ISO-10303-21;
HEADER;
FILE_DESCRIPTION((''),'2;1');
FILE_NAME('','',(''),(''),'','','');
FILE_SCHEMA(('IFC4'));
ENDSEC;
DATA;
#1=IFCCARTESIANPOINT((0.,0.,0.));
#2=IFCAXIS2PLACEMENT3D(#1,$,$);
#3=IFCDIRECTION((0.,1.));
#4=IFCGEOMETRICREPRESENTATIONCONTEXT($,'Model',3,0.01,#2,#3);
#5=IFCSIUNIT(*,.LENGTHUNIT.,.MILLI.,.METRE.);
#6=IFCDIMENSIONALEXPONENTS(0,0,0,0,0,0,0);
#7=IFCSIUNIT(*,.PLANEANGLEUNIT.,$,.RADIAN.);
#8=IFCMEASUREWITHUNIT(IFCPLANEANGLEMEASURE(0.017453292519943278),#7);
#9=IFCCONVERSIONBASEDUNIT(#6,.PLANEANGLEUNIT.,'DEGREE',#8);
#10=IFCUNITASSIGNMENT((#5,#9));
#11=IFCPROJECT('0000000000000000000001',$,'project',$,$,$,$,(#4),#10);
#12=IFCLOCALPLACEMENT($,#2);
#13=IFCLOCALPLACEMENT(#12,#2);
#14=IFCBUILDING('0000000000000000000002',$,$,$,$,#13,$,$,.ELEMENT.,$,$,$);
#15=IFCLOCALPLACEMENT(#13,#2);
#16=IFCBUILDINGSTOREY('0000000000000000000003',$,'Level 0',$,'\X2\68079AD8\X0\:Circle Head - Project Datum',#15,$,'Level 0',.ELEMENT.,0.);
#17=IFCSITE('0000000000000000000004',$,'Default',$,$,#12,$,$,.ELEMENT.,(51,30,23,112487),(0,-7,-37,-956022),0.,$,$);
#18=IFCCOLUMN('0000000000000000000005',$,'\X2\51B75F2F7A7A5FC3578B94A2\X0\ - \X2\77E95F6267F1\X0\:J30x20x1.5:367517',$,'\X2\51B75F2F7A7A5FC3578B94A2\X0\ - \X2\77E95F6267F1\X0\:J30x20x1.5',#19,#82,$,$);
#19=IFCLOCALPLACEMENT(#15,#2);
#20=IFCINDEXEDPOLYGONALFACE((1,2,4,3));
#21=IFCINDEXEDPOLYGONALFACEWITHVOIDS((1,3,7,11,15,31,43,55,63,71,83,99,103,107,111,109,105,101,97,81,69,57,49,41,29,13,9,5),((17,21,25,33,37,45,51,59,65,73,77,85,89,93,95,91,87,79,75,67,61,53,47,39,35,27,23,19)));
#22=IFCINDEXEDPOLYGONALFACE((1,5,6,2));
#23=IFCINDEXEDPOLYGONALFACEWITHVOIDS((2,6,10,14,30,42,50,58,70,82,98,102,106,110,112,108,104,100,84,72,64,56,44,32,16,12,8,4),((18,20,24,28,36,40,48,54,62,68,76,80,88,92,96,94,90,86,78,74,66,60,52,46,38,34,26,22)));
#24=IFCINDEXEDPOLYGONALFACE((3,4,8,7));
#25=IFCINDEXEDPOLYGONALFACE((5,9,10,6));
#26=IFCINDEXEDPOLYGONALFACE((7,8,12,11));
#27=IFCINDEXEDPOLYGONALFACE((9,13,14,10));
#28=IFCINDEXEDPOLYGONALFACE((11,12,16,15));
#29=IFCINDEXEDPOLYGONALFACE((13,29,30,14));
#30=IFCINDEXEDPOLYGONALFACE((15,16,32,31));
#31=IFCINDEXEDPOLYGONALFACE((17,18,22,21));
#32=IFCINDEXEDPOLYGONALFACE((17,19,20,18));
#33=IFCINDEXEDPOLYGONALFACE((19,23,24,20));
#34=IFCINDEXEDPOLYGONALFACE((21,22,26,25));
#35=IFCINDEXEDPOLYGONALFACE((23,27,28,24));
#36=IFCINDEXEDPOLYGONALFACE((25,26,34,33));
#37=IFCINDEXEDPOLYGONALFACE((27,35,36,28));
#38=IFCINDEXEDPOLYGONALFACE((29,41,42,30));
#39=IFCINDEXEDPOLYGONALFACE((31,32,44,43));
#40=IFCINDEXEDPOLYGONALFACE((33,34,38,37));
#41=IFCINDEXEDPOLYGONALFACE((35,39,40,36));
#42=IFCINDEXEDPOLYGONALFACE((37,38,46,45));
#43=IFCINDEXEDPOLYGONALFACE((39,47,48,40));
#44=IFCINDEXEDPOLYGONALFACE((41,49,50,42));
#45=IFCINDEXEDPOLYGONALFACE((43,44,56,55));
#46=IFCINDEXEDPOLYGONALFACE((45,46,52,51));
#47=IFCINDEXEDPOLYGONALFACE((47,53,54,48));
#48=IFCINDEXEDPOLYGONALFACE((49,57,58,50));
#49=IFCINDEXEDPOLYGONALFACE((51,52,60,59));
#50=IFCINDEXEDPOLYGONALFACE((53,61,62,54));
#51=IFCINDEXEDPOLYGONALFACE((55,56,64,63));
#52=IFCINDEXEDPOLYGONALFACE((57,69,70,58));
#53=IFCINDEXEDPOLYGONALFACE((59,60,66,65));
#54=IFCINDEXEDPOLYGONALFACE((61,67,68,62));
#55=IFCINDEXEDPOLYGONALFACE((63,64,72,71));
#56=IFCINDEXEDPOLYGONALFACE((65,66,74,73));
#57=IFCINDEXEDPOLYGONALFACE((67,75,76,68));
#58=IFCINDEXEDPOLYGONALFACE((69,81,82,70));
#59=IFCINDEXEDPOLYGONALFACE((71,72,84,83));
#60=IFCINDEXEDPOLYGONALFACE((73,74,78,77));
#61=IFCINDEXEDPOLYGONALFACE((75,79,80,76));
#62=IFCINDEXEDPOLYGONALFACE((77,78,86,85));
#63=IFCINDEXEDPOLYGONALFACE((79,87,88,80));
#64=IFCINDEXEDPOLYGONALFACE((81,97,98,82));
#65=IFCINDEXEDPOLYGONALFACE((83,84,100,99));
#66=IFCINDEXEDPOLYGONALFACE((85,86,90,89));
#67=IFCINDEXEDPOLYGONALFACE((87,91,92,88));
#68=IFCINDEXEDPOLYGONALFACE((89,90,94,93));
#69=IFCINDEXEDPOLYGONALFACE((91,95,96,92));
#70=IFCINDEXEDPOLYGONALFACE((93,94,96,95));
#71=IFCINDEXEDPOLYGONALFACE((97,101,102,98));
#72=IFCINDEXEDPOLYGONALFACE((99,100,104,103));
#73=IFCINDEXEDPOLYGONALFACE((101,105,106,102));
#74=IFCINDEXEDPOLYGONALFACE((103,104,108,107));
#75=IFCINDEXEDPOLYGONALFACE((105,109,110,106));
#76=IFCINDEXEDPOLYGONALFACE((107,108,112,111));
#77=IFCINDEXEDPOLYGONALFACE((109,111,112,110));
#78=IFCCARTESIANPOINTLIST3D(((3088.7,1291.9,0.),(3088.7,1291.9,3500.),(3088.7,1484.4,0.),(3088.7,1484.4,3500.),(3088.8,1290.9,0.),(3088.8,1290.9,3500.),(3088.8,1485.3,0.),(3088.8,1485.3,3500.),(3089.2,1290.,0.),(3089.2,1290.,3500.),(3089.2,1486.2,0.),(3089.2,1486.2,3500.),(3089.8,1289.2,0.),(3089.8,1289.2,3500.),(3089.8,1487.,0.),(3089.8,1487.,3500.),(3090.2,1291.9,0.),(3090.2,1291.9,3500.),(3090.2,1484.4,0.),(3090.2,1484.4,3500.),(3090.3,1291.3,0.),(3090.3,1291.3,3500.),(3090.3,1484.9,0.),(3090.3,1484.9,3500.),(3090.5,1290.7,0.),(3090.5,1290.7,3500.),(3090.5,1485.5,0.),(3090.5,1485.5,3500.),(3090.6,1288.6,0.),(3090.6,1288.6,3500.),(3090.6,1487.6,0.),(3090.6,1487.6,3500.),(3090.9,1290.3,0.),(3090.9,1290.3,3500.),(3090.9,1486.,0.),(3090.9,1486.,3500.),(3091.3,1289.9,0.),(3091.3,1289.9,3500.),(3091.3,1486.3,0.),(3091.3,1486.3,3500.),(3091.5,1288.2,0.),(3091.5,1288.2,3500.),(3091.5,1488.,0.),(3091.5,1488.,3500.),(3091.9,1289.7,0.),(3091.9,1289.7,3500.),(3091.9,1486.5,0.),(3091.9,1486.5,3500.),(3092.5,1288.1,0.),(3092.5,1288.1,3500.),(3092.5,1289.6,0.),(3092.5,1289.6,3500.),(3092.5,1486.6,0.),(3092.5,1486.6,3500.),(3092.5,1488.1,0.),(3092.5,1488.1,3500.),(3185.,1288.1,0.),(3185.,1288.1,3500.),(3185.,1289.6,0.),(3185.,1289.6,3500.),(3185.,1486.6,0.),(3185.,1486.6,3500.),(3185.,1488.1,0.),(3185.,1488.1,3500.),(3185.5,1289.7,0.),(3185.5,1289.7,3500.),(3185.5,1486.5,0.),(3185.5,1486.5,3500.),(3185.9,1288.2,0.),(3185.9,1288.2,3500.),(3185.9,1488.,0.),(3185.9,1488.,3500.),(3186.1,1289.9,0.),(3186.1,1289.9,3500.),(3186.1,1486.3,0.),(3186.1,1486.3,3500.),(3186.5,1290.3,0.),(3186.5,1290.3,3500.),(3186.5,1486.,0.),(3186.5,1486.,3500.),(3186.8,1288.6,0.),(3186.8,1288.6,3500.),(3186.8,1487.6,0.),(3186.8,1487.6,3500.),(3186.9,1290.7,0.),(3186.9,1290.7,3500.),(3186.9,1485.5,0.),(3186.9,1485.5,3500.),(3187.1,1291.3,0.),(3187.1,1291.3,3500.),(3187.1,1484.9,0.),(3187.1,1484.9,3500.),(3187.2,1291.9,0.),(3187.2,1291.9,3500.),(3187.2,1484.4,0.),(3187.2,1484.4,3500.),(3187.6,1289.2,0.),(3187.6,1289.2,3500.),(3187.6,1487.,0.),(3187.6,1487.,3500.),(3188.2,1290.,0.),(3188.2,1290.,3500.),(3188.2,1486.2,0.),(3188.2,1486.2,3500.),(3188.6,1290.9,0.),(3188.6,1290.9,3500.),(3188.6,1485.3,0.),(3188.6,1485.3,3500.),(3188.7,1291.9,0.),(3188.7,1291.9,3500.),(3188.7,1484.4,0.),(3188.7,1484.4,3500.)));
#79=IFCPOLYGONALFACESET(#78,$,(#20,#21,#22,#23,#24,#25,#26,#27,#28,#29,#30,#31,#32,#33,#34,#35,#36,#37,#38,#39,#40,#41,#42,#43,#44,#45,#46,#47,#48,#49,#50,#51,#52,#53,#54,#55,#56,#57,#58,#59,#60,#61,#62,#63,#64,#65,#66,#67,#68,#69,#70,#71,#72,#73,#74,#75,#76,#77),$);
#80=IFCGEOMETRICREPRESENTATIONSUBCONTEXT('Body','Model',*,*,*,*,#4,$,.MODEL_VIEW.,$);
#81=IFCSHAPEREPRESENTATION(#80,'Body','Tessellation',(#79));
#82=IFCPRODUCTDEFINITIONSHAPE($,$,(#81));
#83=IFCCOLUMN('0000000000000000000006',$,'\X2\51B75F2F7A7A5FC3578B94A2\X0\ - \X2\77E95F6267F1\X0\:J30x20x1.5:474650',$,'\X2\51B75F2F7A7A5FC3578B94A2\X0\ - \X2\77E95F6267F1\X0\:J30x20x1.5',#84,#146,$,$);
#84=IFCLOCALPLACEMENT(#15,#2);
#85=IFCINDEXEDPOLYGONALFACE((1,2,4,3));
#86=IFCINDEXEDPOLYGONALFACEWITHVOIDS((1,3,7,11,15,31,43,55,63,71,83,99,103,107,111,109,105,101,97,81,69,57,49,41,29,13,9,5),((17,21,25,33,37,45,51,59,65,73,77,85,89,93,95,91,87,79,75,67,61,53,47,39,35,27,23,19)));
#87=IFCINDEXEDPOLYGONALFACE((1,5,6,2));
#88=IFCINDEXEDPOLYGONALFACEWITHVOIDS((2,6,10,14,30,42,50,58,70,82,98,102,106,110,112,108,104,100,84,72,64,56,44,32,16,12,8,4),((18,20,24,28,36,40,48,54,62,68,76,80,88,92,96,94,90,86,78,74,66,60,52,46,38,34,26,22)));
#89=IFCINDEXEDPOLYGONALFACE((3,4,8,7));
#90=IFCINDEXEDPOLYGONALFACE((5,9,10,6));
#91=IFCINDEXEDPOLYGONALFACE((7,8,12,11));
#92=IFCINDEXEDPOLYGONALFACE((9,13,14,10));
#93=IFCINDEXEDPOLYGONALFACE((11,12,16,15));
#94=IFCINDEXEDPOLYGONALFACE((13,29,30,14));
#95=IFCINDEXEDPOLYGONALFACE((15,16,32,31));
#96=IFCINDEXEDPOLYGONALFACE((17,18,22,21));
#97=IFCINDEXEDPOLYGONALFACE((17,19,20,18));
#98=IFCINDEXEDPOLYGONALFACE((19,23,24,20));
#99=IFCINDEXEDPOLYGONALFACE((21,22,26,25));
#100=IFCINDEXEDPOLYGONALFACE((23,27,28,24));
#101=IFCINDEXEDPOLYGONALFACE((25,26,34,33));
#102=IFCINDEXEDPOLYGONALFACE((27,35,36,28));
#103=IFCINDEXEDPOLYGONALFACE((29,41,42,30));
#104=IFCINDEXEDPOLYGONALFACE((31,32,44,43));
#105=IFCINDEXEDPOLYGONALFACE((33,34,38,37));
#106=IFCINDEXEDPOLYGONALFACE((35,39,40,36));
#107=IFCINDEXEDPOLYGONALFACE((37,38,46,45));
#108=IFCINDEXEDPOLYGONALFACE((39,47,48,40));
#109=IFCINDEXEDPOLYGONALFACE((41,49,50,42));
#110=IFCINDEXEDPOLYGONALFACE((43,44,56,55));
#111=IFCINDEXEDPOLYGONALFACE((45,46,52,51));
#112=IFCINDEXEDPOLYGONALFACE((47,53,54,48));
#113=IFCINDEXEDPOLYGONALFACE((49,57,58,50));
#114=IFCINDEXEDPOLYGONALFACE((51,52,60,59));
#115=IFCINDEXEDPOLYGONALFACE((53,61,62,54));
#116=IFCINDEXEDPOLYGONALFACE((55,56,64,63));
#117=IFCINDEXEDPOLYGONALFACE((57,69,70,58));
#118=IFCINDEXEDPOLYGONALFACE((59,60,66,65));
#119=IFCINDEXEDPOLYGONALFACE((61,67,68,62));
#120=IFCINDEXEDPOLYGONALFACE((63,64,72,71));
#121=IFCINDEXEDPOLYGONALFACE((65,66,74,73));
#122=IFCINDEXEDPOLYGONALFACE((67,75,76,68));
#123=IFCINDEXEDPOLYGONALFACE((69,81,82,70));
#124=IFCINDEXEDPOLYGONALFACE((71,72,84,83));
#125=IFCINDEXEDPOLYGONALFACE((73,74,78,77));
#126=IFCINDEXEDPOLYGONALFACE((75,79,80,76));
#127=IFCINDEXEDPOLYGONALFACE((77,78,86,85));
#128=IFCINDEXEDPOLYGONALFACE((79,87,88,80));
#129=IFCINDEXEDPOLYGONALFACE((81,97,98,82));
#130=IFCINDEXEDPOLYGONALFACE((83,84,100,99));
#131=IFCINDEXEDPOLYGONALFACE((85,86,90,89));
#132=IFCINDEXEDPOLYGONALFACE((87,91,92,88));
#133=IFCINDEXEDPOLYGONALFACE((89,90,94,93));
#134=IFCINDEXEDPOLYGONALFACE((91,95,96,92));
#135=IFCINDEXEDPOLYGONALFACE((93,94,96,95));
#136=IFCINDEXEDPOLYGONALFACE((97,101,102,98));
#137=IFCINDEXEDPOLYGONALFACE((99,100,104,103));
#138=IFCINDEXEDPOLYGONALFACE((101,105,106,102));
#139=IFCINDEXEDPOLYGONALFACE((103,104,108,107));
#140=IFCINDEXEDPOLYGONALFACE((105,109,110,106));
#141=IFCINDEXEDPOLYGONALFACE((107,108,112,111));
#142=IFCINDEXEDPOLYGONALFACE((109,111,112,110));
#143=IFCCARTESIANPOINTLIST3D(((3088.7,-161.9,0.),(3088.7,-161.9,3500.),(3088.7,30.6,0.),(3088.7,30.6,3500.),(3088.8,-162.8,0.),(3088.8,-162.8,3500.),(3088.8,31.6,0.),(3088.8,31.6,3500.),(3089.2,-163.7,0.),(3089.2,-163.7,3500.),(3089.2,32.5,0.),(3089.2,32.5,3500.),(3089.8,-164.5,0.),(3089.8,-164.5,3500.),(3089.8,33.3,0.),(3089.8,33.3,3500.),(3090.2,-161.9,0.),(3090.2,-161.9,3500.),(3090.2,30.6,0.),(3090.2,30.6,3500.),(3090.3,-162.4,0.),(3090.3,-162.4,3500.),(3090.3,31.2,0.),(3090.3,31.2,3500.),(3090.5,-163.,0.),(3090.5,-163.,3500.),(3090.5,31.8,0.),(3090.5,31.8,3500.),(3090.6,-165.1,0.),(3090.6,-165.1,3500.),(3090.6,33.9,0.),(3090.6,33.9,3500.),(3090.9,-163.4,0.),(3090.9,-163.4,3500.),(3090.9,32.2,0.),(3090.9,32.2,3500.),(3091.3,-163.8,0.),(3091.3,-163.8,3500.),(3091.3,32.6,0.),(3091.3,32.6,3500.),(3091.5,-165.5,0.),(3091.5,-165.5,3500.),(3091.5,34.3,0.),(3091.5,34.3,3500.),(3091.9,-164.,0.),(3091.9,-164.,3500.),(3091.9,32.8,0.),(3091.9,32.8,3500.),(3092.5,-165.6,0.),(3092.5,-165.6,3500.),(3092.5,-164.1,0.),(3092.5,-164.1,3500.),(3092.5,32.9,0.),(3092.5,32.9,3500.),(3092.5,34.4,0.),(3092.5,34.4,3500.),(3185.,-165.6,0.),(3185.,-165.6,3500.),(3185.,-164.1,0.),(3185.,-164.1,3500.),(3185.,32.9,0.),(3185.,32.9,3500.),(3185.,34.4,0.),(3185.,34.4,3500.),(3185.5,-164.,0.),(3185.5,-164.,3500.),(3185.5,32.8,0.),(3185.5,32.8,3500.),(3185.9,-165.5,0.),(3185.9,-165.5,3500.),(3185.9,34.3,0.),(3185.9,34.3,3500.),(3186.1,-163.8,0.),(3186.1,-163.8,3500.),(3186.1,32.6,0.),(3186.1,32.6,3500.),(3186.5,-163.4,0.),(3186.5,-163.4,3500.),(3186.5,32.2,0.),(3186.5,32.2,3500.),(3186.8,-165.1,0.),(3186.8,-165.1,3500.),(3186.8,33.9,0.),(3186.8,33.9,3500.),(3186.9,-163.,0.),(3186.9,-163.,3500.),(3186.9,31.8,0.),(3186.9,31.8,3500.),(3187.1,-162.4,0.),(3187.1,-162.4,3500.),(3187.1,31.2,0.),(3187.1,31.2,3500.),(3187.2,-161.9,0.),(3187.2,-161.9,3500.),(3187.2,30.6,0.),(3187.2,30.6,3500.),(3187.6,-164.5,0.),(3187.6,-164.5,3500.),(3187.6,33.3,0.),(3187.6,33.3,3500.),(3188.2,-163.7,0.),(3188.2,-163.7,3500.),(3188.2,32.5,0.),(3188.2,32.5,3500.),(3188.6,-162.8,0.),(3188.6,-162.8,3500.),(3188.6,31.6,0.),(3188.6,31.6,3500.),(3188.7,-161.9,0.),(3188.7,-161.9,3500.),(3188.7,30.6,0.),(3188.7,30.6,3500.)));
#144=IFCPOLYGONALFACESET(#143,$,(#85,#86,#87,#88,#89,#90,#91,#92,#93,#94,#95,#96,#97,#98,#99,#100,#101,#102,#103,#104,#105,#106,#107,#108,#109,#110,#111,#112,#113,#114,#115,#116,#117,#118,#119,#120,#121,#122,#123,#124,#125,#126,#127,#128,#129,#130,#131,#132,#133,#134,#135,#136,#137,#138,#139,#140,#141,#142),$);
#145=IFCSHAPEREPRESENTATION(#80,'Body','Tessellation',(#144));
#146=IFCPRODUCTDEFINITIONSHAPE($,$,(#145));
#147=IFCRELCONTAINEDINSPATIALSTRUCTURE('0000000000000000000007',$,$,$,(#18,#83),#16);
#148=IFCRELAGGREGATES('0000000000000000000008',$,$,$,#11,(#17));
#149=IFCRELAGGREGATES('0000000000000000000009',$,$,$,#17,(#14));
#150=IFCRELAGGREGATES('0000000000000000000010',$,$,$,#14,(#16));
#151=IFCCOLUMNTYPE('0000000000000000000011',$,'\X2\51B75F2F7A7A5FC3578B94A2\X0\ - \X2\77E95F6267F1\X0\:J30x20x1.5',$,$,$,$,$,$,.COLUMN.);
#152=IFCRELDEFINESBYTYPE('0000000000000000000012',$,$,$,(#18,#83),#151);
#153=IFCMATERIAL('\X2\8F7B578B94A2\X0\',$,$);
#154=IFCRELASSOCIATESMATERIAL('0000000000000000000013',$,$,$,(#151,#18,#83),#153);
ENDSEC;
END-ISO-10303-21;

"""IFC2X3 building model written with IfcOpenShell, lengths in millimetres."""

from ifc_helpers import new_model, entity, si_unit, converted_unit, direction, frame, frame_2d, origin, place, context, subcontext, project, spatial, polyline, circle_curve, parameter, trimmed, segment, composite_curve, outline, extrude, source, transform, mapped, material, type_object, type_shapes, element, save


model = new_model("IFC2X3")

# Units and contexts
model_context = context("Model", 3, precision=0.01, world=origin(), true_north=direction((0.0, 1.0)))
body_context = subcontext(model_context, "Body", "Model", "MODEL_VIEW")
ifc_project = project(units=[si_unit("LENGTHUNIT", "METRE", prefix="MILLI"), converted_unit("PLANEANGLEUNIT", "DEGREE", entity("IfcPlaneAngleMeasure", 0.017453292519943278), si_unit("PLANEANGLEUNIT", "RADIAN"), dimensions=[0, 0, 0, 0, 0, 0, 0])], contexts=[model_context])

# Site, building, storey
site_placement = place(None, origin())
site = spatial("IfcSite", under=ifc_project, at=site_placement, Name="Default", CompositionType="ELEMENT", RefLatitude=(51, 30, 23, 112487), RefLongitude=(0, -7, -37, -956022), RefElevation=0.0)
building_placement = place(site_placement, origin())
building = spatial("IfcBuilding", under=site, at=building_placement, CompositionType="ELEMENT")
storey_placement = place(building_placement, origin())
storey = spatial("IfcBuildingStorey", under=building, at=storey_placement, Name="Level 0", ObjectType="标高:Circle Head - Project Datum", LongName="Level 0", CompositionType="ELEMENT", Elevation=0.0)

# Columns
ifc_material_1 = material(Name="轻型钢")
column_type = type_object("IfcColumnType", Name="冷弯空心型钢 - 矩形柱:J30x20x1.5", PredefinedType="COLUMN", material=ifc_material_1)
shared_shape_1 = source(origin(), body_context, "Body", "SweptSolid", [
    extrude(outline(composite_curve([segment(polyline([(-46.2, -100.0), (46.3, -100.0)]), True, "CONTINUOUS"), segment(trimmed(circle_curve(frame_2d((46.3, -96.3), x_axis=(-1.0, 0.0)), 3.8), [parameter(90.0)], [parameter(180.0)], True, "PARAMETER"), True, "CONTINUOUS"), segment(polyline([(50.0, -96.3), (50.0, 96.3)]), True, "CONTINUOUS"), segment(trimmed(circle_curve(frame_2d((46.2, 96.3), x_axis=(-1.0, 0.0)), 3.8), [parameter(180.0)], [parameter(270.0)], True, "PARAMETER"), True, "CONTINUOUS"), segment(polyline([(46.2, 100.0), (-46.2, 100.0)]), True, "CONTINUOUS"), segment(trimmed(circle_curve(frame_2d((-46.2, 96.3), x_axis=(-1.0, 0.0)), 3.8), [parameter(270.0)], [parameter(0.0)], True, "PARAMETER"), True, "CONTINUOUS"), segment(polyline([(-50.0, 96.3), (-50.0, -96.3)]), True, "CONTINUOUS"), segment(trimmed(circle_curve(frame_2d((-46.2, -96.3), x_axis=(-1.0, 0.0)), 3.8), [parameter(360.0)], [parameter(90.0)], True, "PARAMETER"), True, "CONTINUOUS")], self_intersect=False), holes=[composite_curve([segment(trimmed(circle_curve(frame_2d((-46.3, -96.3), x_axis=(-1.0, 0.0)), 2.2), [parameter(0.0)], [parameter(90.0)], True, "PARAMETER"), False, "CONTINUOUS"), segment(polyline([(-48.5, -96.3), (-48.5, 96.3)]), True, "CONTINUOUS"), segment(trimmed(circle_curve(frame_2d((-46.3, 96.3), x_axis=(-1.0, 0.0)), 2.2), [parameter(270.0)], [parameter(0.0)], True, "PARAMETER"), False, "CONTINUOUS"), segment(polyline([(-46.3, 98.5), (46.2, 98.5)]), True, "CONTINUOUS"), segment(trimmed(circle_curve(frame_2d((46.2, 96.3), x_axis=(-1.0, 0.0)), 2.2), [parameter(180.0)], [parameter(270.0)], True, "PARAMETER"), False, "CONTINUOUS"), segment(polyline([(48.5, 96.3), (48.5, -96.3)]), True, "CONTINUOUS"), segment(trimmed(circle_curve(frame_2d((46.3, -96.3), x_axis=(-1.0, 0.0)), 2.2), [parameter(90.0)], [parameter(180.0)], True, "PARAMETER"), False, "CONTINUOUS"), segment(polyline([(46.3, -98.5), (-46.3, -98.5)]), True, "CONTINUOUS")], self_intersect=False)]), frame((0.0, 0.0, 0.0), z_axis=(0.0, 0.0, 1.0), x_axis=(-1.0, 0.0, 0.0)), (0.0, 0.0, 1.0), 3500.0),
])
type_shapes(column_type, [shared_shape_1])
for number, where, name in (
    (1, (3138.7, 1388.1, 0.0), "冷弯空心型钢 - 矩形柱:J30x20x1.5:367517"),
    (2, (3138.7, -65.6, 0.0), "冷弯空心型钢 - 矩形柱:J30x20x1.5:474650"),
):
    element("IfcColumn", number, at=place(storey_placement, frame(where)), inside=storey, type_object=column_type, material=ifc_material_1, Name=name, ObjectType="冷弯空心型钢 - 矩形柱:J30x20x1.5", context=body_context, shape_type="MappedRepresentation", body=[
        mapped(shared_shape_1, transform((0.0, 0.0, 0.0), scale=1.0)),
    ])

save(model, "model.ifc")
